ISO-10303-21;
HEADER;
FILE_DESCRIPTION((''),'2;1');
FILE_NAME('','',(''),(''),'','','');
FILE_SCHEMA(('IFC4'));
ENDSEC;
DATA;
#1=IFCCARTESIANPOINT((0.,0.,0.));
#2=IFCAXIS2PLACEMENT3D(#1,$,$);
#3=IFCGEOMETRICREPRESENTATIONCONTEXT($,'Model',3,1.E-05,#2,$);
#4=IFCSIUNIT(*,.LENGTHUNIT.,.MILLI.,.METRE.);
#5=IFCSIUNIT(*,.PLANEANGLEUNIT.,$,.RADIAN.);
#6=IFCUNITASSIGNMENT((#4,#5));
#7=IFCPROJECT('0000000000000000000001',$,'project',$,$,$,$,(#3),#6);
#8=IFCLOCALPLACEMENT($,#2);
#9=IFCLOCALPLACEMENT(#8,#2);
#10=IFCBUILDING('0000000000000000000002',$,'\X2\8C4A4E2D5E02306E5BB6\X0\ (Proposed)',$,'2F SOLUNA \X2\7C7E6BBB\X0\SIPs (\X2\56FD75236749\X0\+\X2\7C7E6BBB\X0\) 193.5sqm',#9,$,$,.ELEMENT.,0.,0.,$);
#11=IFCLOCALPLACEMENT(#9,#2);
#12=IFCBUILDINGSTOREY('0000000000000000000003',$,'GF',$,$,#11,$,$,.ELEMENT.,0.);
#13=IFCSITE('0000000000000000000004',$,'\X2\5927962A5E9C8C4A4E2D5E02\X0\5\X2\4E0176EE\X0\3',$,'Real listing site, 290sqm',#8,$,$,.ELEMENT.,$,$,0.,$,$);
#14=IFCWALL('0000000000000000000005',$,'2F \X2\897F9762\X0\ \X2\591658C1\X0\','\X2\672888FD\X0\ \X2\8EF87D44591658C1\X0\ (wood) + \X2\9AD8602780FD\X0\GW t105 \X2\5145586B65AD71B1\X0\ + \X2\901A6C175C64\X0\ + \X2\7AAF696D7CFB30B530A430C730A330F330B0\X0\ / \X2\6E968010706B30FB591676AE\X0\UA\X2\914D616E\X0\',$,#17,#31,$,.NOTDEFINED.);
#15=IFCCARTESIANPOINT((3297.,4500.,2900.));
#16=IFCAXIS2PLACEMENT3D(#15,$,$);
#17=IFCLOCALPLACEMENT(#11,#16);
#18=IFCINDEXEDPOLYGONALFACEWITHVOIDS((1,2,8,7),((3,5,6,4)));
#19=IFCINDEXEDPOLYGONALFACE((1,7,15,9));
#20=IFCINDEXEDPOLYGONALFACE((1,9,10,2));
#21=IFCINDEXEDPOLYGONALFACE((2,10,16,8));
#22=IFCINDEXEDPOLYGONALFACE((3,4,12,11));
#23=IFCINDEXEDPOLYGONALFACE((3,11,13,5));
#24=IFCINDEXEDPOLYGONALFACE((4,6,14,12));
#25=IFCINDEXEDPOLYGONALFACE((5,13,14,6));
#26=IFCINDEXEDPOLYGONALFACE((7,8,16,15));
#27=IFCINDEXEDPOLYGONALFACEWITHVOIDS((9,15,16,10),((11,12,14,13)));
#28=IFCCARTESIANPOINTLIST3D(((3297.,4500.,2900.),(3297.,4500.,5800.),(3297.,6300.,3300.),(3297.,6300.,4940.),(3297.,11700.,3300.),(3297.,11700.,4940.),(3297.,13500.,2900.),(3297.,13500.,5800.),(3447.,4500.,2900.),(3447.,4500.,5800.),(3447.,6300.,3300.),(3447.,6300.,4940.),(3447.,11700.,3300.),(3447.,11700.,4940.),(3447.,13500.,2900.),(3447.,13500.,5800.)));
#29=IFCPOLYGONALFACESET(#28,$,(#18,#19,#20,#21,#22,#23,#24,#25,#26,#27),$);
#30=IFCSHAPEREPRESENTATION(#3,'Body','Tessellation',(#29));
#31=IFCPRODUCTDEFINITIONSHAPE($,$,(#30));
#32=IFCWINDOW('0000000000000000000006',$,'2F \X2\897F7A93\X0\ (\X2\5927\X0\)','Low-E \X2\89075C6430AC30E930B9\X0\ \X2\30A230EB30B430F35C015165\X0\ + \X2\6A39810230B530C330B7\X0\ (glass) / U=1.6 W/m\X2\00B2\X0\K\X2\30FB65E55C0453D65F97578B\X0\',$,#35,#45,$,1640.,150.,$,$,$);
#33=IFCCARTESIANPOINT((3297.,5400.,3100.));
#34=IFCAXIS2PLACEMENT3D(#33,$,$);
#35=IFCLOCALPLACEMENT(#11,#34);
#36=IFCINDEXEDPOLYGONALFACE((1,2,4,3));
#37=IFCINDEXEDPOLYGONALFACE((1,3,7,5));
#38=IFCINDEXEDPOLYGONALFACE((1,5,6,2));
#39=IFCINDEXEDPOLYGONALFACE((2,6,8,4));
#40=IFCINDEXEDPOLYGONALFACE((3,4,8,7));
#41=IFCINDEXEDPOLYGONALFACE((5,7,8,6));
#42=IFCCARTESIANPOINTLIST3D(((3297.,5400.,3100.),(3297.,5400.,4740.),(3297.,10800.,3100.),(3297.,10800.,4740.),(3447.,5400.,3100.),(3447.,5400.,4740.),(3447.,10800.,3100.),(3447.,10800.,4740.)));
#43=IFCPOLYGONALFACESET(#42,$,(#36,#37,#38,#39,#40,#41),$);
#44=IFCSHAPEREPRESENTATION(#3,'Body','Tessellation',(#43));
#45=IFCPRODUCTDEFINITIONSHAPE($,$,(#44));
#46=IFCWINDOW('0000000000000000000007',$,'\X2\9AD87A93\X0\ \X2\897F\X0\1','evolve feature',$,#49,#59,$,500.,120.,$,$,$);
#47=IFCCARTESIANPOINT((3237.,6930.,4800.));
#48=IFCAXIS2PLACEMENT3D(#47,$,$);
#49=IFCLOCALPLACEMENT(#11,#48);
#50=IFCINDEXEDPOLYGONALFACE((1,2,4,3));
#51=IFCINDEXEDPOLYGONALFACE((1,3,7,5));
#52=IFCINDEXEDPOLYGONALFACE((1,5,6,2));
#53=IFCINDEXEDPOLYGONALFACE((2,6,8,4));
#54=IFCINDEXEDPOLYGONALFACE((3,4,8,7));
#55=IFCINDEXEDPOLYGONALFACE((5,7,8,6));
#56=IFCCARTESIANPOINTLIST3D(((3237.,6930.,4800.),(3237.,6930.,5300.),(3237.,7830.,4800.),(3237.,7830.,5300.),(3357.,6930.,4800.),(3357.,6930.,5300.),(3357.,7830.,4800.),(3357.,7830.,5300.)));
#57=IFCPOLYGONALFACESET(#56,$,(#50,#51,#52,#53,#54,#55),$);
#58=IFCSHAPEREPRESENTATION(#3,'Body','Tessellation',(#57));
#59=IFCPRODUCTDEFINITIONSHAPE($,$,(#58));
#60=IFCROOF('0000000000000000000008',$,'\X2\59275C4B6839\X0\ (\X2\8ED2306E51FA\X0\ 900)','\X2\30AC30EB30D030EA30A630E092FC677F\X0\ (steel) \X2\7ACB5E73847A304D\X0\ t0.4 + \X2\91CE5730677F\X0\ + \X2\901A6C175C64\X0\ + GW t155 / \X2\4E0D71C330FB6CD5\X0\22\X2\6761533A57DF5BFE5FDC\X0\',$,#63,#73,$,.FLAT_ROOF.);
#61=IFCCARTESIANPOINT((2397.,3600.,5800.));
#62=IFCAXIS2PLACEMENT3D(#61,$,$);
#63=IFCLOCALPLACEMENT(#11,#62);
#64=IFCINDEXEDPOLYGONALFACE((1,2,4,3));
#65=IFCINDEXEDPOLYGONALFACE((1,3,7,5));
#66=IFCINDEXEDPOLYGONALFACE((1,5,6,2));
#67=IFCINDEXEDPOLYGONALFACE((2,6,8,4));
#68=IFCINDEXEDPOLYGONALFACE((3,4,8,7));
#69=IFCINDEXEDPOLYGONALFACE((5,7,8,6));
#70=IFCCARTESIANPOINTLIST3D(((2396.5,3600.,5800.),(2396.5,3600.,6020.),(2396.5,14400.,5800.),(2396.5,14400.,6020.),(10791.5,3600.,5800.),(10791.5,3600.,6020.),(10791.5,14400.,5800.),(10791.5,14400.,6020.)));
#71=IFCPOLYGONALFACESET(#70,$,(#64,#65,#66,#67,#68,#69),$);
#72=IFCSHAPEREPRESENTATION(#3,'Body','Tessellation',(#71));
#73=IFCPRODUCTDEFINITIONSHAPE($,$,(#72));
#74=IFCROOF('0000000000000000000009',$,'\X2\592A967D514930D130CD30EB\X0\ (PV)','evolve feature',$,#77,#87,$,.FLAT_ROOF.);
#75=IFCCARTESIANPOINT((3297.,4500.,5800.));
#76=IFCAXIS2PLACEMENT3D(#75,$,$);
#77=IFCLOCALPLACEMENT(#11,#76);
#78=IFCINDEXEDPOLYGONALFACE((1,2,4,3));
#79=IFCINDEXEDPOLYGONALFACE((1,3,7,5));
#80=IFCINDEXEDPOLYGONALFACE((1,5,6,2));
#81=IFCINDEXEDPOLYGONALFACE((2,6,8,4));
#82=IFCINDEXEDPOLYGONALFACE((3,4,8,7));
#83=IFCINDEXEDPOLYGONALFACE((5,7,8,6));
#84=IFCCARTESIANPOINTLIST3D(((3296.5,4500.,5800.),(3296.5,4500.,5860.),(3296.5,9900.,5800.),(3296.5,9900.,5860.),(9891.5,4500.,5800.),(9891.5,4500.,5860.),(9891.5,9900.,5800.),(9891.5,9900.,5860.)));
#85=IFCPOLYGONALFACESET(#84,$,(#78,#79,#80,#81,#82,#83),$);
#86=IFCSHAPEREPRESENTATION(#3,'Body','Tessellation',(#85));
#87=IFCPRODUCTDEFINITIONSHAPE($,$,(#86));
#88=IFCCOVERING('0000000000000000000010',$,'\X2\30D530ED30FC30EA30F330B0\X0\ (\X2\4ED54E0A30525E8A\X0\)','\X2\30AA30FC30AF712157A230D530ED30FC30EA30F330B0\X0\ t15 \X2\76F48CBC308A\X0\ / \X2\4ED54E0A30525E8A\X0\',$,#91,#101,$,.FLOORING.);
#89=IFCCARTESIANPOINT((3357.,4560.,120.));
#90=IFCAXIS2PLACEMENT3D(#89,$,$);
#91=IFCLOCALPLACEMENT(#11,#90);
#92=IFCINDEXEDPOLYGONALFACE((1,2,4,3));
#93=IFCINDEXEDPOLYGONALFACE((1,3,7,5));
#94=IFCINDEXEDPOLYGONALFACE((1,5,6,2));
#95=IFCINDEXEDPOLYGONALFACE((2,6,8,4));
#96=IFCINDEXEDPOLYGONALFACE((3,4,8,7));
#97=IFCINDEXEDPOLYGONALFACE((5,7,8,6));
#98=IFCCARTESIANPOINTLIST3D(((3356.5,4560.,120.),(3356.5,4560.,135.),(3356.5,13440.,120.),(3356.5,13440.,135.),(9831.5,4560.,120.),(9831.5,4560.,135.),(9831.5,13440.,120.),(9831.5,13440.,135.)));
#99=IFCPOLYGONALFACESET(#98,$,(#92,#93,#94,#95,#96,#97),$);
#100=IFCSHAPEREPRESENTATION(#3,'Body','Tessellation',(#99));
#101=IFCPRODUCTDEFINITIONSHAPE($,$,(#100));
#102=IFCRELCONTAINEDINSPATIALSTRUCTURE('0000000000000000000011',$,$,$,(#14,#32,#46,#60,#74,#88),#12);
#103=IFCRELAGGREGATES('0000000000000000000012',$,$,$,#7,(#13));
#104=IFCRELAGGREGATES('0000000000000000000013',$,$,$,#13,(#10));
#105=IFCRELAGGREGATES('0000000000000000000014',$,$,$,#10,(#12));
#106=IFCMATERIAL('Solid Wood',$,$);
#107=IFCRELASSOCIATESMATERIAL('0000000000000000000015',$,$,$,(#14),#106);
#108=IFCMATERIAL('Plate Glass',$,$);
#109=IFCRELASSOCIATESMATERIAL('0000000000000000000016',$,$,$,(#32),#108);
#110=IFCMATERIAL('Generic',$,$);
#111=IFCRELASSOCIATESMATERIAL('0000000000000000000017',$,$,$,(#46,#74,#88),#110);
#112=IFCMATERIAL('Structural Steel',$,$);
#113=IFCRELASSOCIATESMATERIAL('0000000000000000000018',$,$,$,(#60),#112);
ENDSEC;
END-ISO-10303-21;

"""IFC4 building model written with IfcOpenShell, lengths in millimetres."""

from ifc_helpers import new_model, si_unit, frame, frame_2d, origin, place, context, project, spatial, rectangle, extrude, material, element, fill, save


model = new_model("IFC4")

# Units and contexts
model_context = context("Model", 3, precision=1e-05, world=origin())
ifc_project = project(units=[si_unit("LENGTHUNIT", "METRE", prefix="MILLI"), si_unit("PLANEANGLEUNIT", "RADIAN")], contexts=[model_context])

# Site, building, storey
site_placement = place(None, origin())
site = spatial("IfcSite", under=ifc_project, at=site_placement, Name="大阪府豊中市5丁目3", ObjectType="Real listing site, 290sqm", CompositionType="ELEMENT", RefElevation=0.0)
building_placement = place(site_placement, origin())
building = spatial("IfcBuilding", under=site, at=building_placement, Name="豊中市の家 (Proposed)", ObjectType="2F SOLUNA 籾殻SIPs (国産杉+籾殻) 193.5sqm", CompositionType="ELEMENT", ElevationOfRefHeight=0.0, ElevationOfTerrain=0.0)
storey_placement = place(building_placement, origin())
storey = spatial("IfcBuildingStorey", under=building, at=storey_placement, Name="GF", CompositionType="ELEMENT", Elevation=0.0)

# Shared definitions
ifc_material_1 = material(Name="Solid Wood")

# Shared definitions
ifc_material_2 = material(Name="Plate Glass")
ifc_material_3 = material(Name="Generic")

# Wall, openings, windows
wall_1_placement = place(storey_placement, frame((3297.0, 4500.0, 2900.0)))
wall_1 = element("IfcWall", 1, at=wall_1_placement, inside=storey, material=ifc_material_1, Name="2F 西面 外壁", Description="木製 軸組外壁 (wood) + 高性能GW t105 充填断熱 + 通気層 + 窯業系サイディング / 準耐火・外皮UA配慮", PredefinedType="NOTDEFINED", context=model_context, shape_type="SweptSolid", body=[
    extrude(rectangle(XDim=150.0, YDim=9000.0, at=frame_2d((75.0, 4500.0))), frame((3297.0, 4500.0, 2900.0)), (0.0, 0.0, 1.0), 2900.0),
])
opening_1_placement = place(storey_placement, frame((3297.0, 5400.0, 3100.0)))
opening_1 = element("IfcOpeningElement", 2, at=opening_1_placement, cuts=wall_1, PredefinedType="NOTDEFINED", context=model_context, shape_type="SweptSolid", body=[
    extrude(rectangle(XDim=150.0, YDim=5400.0, at=frame_2d((75.0, 2700.0))), frame((3297.0, 5400.0, 3100.0)), (0.0, 0.0, 1.0), 1640.0),
])
opening_2_placement = place(storey_placement, frame((3237.0, 6930.0, 4800.0)))
opening_2 = element("IfcOpeningElement", 3, at=opening_2_placement, cuts=wall_1, PredefinedType="NOTDEFINED", context=model_context, shape_type="SweptSolid", body=[
    extrude(rectangle(XDim=120.0, YDim=900.0, at=frame_2d((60.0, 450.0))), frame((3237.0, 6930.0, 4800.0)), (0.0, 0.0, 1.0), 500.0),
])
window_1_placement = place(storey_placement, frame((3297.0, 5400.0, 3100.0)))
window_1 = element("IfcWindow", 4, at=window_1_placement, inside=storey, material=ifc_material_2, Name="2F 西窓 (大)", Description="Low-E 複層ガラス アルゴン封入 + 樹脂サッシ (glass) / U=1.6 W/m²K・日射取得型", OverallHeight=1640.0, OverallWidth=150.0, context=model_context, shape_type="SweptSolid", body=[
    extrude(rectangle(XDim=150.0, YDim=5400.0, at=frame_2d((75.0, 2700.0))), frame((3297.0, 5400.0, 3100.0)), (0.0, 0.0, 1.0), 1640.0),
])
fill(opening_1, window_1)
window_2_placement = place(storey_placement, frame((3237.0, 6930.0, 4800.0)))
window_2 = element("IfcWindow", 5, at=window_2_placement, inside=storey, material=ifc_material_3, Name="高窓 西1", Description="evolve feature", OverallHeight=500.0, OverallWidth=120.0, context=model_context, shape_type="SweptSolid", body=[
    extrude(rectangle(XDim=120.0, YDim=900.0, at=frame_2d((60.0, 450.0))), frame((3237.0, 6930.0, 4800.0)), (0.0, 0.0, 1.0), 500.0),
])
fill(opening_2, window_2)

# Roofs
ifc_material_4 = material(Name="Structural Steel")
roof_1_placement = place(storey_placement, frame((2397.0, 3600.0, 5800.0)))
element("IfcRoof", 6, at=roof_1_placement, inside=storey, material=ifc_material_4, Name="大屋根 (軒の出 900)", Description="ガルバリウム鋼板 (steel) 立平葺き t0.4 + 野地板 + 通気層 + GW t155 / 不燃・法22条区域対応", PredefinedType="FLAT_ROOF", context=model_context, shape_type="SweptSolid", body=[
    extrude(rectangle(XDim=8395.0, YDim=10800.0, at=frame_2d((4197.0, 5400.0))), frame((2397.0, 3600.0, 5800.0)), (0.0, 0.0, 1.0), 220.0),
])
roof_2_placement = place(storey_placement, frame((3297.0, 4500.0, 5800.0)))
element("IfcRoof", 7, at=roof_2_placement, inside=storey, material=ifc_material_3, Name="太陽光パネル (PV)", Description="evolve feature", PredefinedType="FLAT_ROOF", context=model_context, shape_type="SweptSolid", body=[
    extrude(rectangle(XDim=6595.0, YDim=5400.0, at=frame_2d((3297.0, 2700.0))), frame((3297.0, 4500.0, 5800.0)), (0.0, 0.0, 1.0), 60.0),
])

# Covering
covering_placement = place(storey_placement, frame((3357.0, 4560.0, 120.0)))
element("IfcCovering", 8, at=covering_placement, inside=storey, material=ifc_material_3, Name="フローリング (仕上げ床)", Description="オーク無垢フローリング t15 直貼り / 仕上げ床", PredefinedType="FLOORING", context=model_context, shape_type="SweptSolid", body=[
    extrude(rectangle(XDim=6475.0, YDim=8880.0, at=frame_2d((3237.0, 4440.0))), frame((3357.0, 4560.0, 120.0)), (0.0, 0.0, 1.0), 15.0),
])

save(model, "model.ifc")
